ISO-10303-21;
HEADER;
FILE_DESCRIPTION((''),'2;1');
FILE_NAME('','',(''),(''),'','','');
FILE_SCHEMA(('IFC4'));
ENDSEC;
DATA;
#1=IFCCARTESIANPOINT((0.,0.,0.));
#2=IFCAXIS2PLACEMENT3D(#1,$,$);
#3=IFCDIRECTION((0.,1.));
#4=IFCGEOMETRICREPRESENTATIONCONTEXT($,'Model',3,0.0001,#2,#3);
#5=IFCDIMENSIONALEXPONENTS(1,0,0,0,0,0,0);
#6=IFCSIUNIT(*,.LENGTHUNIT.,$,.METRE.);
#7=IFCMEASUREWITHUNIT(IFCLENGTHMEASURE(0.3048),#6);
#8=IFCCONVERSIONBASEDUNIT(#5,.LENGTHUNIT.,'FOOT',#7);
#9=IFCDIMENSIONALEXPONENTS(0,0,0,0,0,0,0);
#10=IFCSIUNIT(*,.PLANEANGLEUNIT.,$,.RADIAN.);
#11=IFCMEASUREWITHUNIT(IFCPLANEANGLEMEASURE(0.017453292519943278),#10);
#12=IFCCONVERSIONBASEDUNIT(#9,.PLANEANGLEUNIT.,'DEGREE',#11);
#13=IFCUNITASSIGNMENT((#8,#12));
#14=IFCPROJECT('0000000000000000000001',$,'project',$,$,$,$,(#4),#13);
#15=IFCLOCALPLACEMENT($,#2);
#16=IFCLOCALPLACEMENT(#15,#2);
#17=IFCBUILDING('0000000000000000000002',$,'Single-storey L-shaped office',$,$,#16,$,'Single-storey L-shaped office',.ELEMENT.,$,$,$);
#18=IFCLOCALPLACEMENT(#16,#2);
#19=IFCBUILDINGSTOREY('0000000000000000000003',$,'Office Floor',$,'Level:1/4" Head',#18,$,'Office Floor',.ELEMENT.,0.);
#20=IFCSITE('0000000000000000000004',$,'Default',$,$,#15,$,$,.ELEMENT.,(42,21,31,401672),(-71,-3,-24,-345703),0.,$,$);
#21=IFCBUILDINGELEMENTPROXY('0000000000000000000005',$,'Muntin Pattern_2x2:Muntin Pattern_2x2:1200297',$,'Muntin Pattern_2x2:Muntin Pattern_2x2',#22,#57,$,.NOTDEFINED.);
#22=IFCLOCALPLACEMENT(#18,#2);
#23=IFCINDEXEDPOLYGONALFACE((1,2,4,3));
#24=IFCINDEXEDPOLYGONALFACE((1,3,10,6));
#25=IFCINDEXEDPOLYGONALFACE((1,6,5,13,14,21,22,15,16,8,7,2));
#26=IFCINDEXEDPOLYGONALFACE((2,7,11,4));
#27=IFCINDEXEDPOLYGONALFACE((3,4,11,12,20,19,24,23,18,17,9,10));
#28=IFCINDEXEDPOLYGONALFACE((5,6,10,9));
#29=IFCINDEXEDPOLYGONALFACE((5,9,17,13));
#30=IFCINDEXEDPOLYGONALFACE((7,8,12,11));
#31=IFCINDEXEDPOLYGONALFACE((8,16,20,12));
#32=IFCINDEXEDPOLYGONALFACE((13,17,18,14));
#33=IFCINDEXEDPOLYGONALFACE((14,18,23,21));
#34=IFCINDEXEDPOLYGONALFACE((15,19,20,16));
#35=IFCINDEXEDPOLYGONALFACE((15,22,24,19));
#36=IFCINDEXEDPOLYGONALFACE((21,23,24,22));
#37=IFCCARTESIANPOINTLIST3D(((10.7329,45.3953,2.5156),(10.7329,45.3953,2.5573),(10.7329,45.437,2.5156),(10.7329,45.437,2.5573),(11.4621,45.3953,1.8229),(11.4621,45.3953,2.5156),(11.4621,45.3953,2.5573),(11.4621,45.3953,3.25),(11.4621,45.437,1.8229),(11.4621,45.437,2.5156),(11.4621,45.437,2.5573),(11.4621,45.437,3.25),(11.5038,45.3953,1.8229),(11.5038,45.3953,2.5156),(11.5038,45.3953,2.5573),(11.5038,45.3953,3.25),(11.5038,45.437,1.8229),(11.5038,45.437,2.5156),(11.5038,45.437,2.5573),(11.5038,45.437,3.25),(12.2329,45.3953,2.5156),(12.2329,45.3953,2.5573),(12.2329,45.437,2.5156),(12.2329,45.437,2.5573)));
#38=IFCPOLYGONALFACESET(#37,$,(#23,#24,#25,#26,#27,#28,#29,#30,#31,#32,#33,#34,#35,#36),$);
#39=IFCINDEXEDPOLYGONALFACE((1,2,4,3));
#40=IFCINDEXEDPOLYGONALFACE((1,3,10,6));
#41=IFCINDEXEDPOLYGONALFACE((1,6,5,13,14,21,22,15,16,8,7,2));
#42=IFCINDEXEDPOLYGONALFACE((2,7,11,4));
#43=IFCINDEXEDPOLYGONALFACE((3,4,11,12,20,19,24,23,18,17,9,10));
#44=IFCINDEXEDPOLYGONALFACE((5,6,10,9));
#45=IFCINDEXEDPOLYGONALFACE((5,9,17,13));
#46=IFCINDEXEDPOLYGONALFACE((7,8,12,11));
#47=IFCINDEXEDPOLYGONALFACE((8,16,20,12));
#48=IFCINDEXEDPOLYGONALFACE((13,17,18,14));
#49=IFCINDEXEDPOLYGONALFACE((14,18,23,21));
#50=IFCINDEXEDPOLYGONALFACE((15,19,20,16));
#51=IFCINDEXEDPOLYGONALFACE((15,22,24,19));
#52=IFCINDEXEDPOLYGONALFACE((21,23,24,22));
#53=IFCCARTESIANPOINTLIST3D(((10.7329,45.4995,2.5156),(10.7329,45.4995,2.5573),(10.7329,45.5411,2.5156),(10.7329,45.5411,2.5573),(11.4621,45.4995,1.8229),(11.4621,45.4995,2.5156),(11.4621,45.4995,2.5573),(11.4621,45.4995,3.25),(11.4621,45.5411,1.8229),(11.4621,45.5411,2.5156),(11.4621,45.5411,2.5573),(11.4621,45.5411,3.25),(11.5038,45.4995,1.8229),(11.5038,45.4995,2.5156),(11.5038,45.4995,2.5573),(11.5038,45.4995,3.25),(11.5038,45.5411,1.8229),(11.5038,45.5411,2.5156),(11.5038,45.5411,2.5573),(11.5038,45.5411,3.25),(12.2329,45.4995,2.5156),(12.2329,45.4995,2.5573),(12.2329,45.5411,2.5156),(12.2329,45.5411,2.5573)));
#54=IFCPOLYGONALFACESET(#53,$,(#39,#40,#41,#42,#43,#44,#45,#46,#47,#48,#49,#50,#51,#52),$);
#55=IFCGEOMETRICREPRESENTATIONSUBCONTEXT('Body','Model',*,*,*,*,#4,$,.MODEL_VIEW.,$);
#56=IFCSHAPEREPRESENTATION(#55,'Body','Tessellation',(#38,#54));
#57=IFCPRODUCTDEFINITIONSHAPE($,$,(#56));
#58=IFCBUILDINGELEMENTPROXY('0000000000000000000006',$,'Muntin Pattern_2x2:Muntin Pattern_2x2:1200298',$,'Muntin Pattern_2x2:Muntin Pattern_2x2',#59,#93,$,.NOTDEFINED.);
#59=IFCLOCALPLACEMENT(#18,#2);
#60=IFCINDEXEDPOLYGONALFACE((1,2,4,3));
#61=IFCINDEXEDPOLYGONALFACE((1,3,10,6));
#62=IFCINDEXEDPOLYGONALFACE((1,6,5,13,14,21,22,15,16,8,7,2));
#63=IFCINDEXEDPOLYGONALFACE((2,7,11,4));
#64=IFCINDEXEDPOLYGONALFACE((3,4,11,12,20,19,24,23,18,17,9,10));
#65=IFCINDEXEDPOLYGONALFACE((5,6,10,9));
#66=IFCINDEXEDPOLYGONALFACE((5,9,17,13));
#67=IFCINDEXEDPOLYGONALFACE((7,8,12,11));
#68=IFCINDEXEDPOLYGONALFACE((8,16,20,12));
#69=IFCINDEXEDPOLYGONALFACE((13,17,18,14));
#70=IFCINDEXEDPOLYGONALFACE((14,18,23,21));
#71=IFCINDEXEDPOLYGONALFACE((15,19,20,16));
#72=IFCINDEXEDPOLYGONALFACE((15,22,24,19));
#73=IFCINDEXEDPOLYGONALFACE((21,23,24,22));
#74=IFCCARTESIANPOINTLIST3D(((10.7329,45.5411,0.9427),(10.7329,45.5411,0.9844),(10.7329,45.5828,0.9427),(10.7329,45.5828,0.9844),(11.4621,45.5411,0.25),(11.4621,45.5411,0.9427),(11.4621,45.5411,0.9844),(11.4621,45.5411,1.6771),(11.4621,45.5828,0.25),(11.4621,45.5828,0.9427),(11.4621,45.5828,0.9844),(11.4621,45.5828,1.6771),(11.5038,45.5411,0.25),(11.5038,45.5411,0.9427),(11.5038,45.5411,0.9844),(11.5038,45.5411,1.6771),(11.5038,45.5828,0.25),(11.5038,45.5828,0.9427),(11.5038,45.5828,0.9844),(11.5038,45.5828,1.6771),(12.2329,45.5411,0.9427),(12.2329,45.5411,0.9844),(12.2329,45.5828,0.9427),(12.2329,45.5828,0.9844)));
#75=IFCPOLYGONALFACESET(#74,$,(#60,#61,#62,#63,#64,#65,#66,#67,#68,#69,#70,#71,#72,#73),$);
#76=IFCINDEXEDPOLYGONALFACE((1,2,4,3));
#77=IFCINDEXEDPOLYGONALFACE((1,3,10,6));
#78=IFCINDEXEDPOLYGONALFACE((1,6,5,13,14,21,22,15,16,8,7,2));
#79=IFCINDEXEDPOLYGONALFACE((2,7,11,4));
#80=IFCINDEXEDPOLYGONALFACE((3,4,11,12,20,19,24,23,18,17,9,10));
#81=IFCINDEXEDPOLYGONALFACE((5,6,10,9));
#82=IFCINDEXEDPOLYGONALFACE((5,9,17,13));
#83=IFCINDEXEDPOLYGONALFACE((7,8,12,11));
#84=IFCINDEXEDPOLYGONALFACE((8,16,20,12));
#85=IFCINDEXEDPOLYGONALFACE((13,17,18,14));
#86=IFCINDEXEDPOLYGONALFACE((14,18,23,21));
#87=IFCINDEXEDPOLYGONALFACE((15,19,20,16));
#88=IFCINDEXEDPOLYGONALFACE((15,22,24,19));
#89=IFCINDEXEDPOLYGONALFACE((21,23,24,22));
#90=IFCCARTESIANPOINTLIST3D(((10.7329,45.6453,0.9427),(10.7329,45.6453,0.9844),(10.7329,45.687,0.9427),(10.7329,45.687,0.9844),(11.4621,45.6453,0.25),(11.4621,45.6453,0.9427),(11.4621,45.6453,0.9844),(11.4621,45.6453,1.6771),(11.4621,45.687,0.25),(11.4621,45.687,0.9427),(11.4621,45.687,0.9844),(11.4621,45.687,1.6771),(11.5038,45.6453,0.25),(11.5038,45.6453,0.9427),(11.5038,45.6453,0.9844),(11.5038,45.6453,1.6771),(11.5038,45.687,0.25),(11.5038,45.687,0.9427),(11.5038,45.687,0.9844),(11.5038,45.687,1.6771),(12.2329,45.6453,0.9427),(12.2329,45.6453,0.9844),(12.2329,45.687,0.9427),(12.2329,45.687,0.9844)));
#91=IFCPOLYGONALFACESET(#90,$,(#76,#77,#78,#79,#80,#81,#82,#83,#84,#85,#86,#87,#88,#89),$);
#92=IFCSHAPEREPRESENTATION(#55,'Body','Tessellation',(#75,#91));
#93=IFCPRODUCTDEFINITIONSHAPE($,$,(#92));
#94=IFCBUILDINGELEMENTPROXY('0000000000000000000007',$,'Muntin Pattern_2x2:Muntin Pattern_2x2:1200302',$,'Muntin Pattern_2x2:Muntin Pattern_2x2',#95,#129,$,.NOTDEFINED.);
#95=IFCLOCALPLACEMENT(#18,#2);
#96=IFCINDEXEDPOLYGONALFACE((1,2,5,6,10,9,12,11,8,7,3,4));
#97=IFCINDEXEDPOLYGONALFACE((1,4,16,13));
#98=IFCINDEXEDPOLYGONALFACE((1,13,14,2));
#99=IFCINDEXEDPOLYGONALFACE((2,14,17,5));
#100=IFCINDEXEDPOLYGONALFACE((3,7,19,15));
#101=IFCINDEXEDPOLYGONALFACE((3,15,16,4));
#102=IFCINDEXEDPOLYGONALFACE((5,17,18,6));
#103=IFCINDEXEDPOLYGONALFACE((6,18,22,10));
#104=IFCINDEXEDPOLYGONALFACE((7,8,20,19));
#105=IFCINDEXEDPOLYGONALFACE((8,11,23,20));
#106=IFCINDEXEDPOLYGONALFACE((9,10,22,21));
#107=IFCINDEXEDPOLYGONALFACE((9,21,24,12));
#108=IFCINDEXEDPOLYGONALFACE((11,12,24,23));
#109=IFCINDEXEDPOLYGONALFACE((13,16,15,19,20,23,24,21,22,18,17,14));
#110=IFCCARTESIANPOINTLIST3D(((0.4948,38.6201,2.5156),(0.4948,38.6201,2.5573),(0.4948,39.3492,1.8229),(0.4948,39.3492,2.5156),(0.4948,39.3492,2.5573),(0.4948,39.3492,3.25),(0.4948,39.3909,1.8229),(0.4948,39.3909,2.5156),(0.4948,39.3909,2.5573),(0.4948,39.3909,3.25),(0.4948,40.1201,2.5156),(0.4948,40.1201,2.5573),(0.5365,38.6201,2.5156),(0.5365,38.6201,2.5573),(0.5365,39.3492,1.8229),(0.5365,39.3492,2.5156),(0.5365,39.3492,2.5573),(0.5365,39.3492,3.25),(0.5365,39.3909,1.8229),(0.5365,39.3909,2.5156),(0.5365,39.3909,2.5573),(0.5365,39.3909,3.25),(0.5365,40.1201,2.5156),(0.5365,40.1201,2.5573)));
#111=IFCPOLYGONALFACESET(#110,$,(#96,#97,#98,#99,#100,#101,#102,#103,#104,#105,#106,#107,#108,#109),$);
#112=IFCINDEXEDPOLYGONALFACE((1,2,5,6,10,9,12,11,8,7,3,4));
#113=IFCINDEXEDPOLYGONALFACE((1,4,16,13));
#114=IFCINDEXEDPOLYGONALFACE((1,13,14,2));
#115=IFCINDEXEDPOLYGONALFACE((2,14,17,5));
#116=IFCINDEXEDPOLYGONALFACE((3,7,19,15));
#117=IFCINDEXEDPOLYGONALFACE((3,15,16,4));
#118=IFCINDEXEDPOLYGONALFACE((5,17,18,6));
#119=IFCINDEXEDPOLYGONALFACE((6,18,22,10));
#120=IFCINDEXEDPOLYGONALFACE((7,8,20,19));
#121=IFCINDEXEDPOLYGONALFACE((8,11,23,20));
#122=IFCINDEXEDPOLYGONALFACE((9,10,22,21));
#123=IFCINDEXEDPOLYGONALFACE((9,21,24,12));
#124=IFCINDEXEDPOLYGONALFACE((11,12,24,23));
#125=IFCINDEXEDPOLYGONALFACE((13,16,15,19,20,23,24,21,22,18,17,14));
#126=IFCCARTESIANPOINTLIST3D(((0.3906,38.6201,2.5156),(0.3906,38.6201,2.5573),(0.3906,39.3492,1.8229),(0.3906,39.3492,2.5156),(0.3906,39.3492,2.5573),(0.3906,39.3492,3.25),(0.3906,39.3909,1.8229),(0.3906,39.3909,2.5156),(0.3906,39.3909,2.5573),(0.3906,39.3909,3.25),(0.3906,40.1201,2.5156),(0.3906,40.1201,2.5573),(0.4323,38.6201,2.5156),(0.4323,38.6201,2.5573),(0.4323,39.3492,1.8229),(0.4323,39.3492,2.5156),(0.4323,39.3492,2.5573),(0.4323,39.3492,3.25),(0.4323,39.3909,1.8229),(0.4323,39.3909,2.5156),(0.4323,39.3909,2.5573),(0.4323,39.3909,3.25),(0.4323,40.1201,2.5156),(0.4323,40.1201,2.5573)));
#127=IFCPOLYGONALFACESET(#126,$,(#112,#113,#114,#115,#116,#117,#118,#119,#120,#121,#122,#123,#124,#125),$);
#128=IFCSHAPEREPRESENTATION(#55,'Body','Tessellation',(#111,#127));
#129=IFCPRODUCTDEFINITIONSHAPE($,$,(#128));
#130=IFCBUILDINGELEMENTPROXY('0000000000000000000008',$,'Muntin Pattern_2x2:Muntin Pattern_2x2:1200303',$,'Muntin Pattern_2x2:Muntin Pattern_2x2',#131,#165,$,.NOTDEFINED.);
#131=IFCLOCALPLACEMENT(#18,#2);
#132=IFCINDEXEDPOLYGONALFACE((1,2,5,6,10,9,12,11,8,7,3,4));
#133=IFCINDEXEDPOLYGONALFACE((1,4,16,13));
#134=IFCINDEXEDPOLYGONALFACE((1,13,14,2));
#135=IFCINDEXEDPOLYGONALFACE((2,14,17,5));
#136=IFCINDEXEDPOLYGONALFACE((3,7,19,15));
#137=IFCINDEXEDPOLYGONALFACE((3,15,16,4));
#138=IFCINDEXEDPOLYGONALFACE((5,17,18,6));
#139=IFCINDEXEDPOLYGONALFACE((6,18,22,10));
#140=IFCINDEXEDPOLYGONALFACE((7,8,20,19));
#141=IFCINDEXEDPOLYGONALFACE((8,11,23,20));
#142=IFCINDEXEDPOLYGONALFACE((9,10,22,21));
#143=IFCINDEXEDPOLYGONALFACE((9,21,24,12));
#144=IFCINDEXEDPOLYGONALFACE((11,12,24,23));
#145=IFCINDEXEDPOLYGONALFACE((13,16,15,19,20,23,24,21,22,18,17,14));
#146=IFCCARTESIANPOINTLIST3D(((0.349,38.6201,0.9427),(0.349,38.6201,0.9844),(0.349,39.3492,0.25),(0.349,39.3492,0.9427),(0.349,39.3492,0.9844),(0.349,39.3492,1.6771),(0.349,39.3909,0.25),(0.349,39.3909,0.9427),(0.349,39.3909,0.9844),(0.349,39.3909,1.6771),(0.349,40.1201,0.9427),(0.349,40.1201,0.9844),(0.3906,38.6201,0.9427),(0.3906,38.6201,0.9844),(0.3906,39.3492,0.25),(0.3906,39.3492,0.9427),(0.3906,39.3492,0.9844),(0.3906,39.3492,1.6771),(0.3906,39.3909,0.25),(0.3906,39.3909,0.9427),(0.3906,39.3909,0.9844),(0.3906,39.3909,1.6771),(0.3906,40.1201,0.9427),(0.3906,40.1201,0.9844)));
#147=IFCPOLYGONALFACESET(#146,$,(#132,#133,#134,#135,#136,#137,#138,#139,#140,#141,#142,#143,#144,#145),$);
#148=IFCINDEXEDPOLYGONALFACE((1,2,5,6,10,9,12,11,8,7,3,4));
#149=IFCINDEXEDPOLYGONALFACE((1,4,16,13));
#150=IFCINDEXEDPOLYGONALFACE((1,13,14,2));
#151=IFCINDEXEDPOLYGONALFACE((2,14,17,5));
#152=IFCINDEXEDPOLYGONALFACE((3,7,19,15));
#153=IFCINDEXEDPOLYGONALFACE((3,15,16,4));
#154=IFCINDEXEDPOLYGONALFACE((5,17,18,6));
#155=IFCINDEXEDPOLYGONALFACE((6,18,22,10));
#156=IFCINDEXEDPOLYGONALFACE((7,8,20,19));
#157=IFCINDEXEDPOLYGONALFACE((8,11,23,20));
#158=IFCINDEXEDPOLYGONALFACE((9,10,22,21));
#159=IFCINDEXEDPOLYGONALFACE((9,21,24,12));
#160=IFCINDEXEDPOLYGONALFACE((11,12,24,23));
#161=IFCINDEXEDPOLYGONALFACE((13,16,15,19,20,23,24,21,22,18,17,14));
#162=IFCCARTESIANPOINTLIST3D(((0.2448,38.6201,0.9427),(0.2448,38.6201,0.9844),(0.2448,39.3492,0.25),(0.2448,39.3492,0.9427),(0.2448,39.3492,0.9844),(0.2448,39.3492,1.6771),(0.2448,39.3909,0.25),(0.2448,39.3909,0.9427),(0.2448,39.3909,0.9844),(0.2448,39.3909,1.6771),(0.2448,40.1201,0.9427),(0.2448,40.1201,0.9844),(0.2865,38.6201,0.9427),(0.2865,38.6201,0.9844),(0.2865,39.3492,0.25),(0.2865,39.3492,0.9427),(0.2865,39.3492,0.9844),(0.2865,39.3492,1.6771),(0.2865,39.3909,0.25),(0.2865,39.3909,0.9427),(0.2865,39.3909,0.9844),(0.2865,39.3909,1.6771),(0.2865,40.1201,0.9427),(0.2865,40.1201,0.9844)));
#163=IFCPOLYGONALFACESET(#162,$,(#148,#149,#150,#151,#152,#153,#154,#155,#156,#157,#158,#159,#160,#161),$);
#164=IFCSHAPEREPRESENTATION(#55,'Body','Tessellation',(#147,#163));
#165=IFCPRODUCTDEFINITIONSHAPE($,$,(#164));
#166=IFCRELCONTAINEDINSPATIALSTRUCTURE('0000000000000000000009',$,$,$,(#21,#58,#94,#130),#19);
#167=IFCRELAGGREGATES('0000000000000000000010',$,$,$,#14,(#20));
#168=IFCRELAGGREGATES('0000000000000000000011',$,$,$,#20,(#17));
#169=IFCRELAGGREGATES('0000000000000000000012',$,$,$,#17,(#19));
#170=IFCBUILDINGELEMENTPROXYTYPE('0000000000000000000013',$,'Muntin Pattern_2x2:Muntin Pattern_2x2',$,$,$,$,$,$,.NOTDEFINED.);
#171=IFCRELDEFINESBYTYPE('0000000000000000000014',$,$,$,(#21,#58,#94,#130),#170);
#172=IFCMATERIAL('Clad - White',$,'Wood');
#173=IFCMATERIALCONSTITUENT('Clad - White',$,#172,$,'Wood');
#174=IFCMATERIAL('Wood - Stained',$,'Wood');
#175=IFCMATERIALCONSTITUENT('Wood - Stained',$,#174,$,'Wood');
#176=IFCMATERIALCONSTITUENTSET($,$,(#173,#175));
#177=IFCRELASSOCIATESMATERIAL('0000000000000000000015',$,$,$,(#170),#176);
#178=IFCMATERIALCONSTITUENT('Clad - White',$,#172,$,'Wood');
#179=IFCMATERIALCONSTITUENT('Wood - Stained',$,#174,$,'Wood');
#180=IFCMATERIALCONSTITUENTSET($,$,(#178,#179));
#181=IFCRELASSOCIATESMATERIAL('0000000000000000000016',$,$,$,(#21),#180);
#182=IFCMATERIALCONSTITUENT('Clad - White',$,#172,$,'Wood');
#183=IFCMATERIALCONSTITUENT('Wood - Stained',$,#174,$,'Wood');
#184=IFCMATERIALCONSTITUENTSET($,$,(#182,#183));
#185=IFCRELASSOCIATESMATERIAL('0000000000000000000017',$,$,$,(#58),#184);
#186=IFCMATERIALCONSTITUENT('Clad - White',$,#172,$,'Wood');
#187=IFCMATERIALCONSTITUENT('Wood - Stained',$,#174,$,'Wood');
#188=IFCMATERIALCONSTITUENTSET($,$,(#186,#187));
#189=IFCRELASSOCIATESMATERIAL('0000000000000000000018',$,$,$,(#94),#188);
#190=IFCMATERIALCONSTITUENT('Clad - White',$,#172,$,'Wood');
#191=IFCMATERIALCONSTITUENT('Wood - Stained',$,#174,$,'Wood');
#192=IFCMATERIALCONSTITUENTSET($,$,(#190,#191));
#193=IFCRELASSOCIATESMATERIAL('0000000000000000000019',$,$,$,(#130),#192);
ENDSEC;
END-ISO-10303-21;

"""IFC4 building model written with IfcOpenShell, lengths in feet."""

from ifc_helpers import new_model, entity, si_unit, converted_unit, direction, frame, origin, place, context, subcontext, project, spatial, indexed_curve, outline, extrude, source, transform, mapped, material, constituent, constituent_set, type_object, type_shapes, element, save


model = new_model("IFC4")

# Units and contexts
model_context = context("Model", 3, precision=0.0001, world=origin(), true_north=direction((0.0, 1.0)))
body_context = subcontext(model_context, "Body", "Model", "MODEL_VIEW")
ifc_project = project(units=[converted_unit("LENGTHUNIT", "FOOT", entity("IfcLengthMeasure", 0.3048), si_unit("LENGTHUNIT", "METRE"), dimensions=[1, 0, 0, 0, 0, 0, 0]), converted_unit("PLANEANGLEUNIT", "DEGREE", entity("IfcPlaneAngleMeasure", 0.017453292519943278), si_unit("PLANEANGLEUNIT", "RADIAN"), dimensions=[0, 0, 0, 0, 0, 0, 0])], contexts=[model_context])

# Site, building, storey
site_placement = place(None, origin())
site = spatial("IfcSite", under=ifc_project, at=site_placement, Name="Default", CompositionType="ELEMENT", RefLatitude=(42, 21, 31, 401672), RefLongitude=(-71, -3, -24, -345703), RefElevation=0.0)
building_placement = place(site_placement, origin())
building = spatial("IfcBuilding", under=site, at=building_placement, Name="Single-storey L-shaped office", LongName="Single-storey L-shaped office", CompositionType="ELEMENT")
storey_placement = place(building_placement, origin())
storey = spatial("IfcBuildingStorey", under=building, at=storey_placement, Name="Office Floor", ObjectType="Level:1/4\" Head", LongName="Office Floor", CompositionType="ELEMENT", Elevation=0.0)

# Shared definitions
ifc_material_1 = material(Name="Wood - Stained", Category="Wood")

# Building element proxies
ifc_material_2 = material(Name="Clad - White", Category="Wood")
ifc_constituent_1 = constituent(ifc_material_2, Name="Clad - White", Category="Wood")
ifc_constituent_2 = constituent(ifc_material_1, Name="Wood - Stained", Category="Wood")
ifc_constituent_set_1 = constituent_set(constituents=[ifc_constituent_1, ifc_constituent_2])
building_element_proxy_type_1 = type_object("IfcBuildingElementProxyType", Name="Muntin Pattern_2x2:Muntin Pattern_2x2", PredefinedType="NOTDEFINED", material=ifc_constituent_set_1)
shared_shape_1 = source(origin(), body_context, "Body", "SweptSolid", [
    extrude(outline(indexed_curve([(0.0208, -0.0208), (0.7135, -0.0208), (0.7135, 0.0208), (0.0208, 0.0208), (0.0208, 0.75), (-0.0208, 0.75), (-0.0208, 0.0208), (-0.7135, 0.0208), (-0.7135, -0.0208), (-0.0208, -0.0208), (-0.0208, -0.75), (0.0208, -0.75), (0.0208, -0.0208)], self_intersect=False)), frame((0.0, 0.0312, 0.7135), z_axis=(0.0, 1.0, 0.0), x_axis=(0.0, 0.0, 1.0)), (0.0, 0.0, 1.0), 0.0417),
    extrude(outline(indexed_curve([(0.0208, -0.0208), (0.7135, -0.0208), (0.7135, 0.0208), (0.0208, 0.0208), (0.0208, 0.75), (-0.0208, 0.75), (-0.0208, 0.0208), (-0.7135, 0.0208), (-0.7135, -0.0208), (-0.0208, -0.0208), (-0.0208, -0.75), (0.0208, -0.75), (0.0208, -0.0208)], self_intersect=False)), frame((0.0, -0.0729, 0.7135), z_axis=(0.0, 1.0, 0.0), x_axis=(0.0, 0.0, 1.0)), (0.0, 0.0, 1.0), 0.0417),
])
type_shapes(building_element_proxy_type_1, [shared_shape_1])
ifc_constituent_3 = constituent(ifc_material_2, Name="Clad - White", Category="Wood")
ifc_constituent_4 = constituent(ifc_material_1, Name="Wood - Stained", Category="Wood")
ifc_constituent_set_2 = constituent_set(constituents=[ifc_constituent_3, ifc_constituent_4])
proxy_1_placement = place(storey_placement, frame((11.4829, 45.4682, 1.8229), z_axis=(0.0, 0.0, 1.0), x_axis=(-1.0, 0.0, 0.0)))
element("IfcBuildingElementProxy", 1, at=proxy_1_placement, inside=storey, type_object=building_element_proxy_type_1, material=ifc_constituent_set_2, Name="Muntin Pattern_2x2:Muntin Pattern_2x2:1200297", ObjectType="Muntin Pattern_2x2:Muntin Pattern_2x2", PredefinedType="NOTDEFINED", context=body_context, shape_type="MappedRepresentation", body=[
    mapped(shared_shape_1, transform((0.0, 0.0, 0.0), scale=1.0)),
])
ifc_constituent_5 = constituent(ifc_material_2, Name="Clad - White", Category="Wood")
ifc_constituent_6 = constituent(ifc_material_1, Name="Wood - Stained", Category="Wood")
ifc_constituent_set_3 = constituent_set(constituents=[ifc_constituent_5, ifc_constituent_6])
proxy_2_placement = place(storey_placement, frame((11.4829, 45.6141, 0.25), z_axis=(0.0, 0.0, 1.0), x_axis=(-1.0, 0.0, 0.0)))
element("IfcBuildingElementProxy", 2, at=proxy_2_placement, inside=storey, type_object=building_element_proxy_type_1, material=ifc_constituent_set_3, Name="Muntin Pattern_2x2:Muntin Pattern_2x2:1200298", ObjectType="Muntin Pattern_2x2:Muntin Pattern_2x2", PredefinedType="NOTDEFINED", context=body_context, shape_type="MappedRepresentation", body=[
    mapped(shared_shape_1, transform((0.0, 0.0, 0.0), scale=1.0)),
])
ifc_constituent_7 = constituent(ifc_material_2, Name="Clad - White", Category="Wood")
ifc_constituent_8 = constituent(ifc_material_1, Name="Wood - Stained", Category="Wood")
ifc_constituent_set_4 = constituent_set(constituents=[ifc_constituent_7, ifc_constituent_8])
proxy_3_placement = place(storey_placement, frame((0.4635, 39.3701, 1.8229), z_axis=(0.0, 0.0, 1.0), x_axis=(0.0, -1.0, 0.0)))
element("IfcBuildingElementProxy", 3, at=proxy_3_placement, inside=storey, type_object=building_element_proxy_type_1, material=ifc_constituent_set_4, Name="Muntin Pattern_2x2:Muntin Pattern_2x2:1200302", ObjectType="Muntin Pattern_2x2:Muntin Pattern_2x2", PredefinedType="NOTDEFINED", context=body_context, shape_type="MappedRepresentation", body=[
    mapped(shared_shape_1, transform((0.0, 0.0, 0.0), scale=1.0)),
])
ifc_constituent_9 = constituent(ifc_material_2, Name="Clad - White", Category="Wood")
ifc_constituent_10 = constituent(ifc_material_1, Name="Wood - Stained", Category="Wood")
ifc_constituent_set_5 = constituent_set(constituents=[ifc_constituent_9, ifc_constituent_10])
proxy_4_placement = place(storey_placement, frame((0.3177, 39.3701, 0.25), z_axis=(0.0, 0.0, 1.0), x_axis=(0.0, -1.0, 0.0)))
element("IfcBuildingElementProxy", 4, at=proxy_4_placement, inside=storey, type_object=building_element_proxy_type_1, material=ifc_constituent_set_5, Name="Muntin Pattern_2x2:Muntin Pattern_2x2:1200303", ObjectType="Muntin Pattern_2x2:Muntin Pattern_2x2", PredefinedType="NOTDEFINED", context=body_context, shape_type="MappedRepresentation", body=[
    mapped(shared_shape_1, transform((0.0, 0.0, 0.0), scale=1.0)),
])

save(model, "model.ifc")
